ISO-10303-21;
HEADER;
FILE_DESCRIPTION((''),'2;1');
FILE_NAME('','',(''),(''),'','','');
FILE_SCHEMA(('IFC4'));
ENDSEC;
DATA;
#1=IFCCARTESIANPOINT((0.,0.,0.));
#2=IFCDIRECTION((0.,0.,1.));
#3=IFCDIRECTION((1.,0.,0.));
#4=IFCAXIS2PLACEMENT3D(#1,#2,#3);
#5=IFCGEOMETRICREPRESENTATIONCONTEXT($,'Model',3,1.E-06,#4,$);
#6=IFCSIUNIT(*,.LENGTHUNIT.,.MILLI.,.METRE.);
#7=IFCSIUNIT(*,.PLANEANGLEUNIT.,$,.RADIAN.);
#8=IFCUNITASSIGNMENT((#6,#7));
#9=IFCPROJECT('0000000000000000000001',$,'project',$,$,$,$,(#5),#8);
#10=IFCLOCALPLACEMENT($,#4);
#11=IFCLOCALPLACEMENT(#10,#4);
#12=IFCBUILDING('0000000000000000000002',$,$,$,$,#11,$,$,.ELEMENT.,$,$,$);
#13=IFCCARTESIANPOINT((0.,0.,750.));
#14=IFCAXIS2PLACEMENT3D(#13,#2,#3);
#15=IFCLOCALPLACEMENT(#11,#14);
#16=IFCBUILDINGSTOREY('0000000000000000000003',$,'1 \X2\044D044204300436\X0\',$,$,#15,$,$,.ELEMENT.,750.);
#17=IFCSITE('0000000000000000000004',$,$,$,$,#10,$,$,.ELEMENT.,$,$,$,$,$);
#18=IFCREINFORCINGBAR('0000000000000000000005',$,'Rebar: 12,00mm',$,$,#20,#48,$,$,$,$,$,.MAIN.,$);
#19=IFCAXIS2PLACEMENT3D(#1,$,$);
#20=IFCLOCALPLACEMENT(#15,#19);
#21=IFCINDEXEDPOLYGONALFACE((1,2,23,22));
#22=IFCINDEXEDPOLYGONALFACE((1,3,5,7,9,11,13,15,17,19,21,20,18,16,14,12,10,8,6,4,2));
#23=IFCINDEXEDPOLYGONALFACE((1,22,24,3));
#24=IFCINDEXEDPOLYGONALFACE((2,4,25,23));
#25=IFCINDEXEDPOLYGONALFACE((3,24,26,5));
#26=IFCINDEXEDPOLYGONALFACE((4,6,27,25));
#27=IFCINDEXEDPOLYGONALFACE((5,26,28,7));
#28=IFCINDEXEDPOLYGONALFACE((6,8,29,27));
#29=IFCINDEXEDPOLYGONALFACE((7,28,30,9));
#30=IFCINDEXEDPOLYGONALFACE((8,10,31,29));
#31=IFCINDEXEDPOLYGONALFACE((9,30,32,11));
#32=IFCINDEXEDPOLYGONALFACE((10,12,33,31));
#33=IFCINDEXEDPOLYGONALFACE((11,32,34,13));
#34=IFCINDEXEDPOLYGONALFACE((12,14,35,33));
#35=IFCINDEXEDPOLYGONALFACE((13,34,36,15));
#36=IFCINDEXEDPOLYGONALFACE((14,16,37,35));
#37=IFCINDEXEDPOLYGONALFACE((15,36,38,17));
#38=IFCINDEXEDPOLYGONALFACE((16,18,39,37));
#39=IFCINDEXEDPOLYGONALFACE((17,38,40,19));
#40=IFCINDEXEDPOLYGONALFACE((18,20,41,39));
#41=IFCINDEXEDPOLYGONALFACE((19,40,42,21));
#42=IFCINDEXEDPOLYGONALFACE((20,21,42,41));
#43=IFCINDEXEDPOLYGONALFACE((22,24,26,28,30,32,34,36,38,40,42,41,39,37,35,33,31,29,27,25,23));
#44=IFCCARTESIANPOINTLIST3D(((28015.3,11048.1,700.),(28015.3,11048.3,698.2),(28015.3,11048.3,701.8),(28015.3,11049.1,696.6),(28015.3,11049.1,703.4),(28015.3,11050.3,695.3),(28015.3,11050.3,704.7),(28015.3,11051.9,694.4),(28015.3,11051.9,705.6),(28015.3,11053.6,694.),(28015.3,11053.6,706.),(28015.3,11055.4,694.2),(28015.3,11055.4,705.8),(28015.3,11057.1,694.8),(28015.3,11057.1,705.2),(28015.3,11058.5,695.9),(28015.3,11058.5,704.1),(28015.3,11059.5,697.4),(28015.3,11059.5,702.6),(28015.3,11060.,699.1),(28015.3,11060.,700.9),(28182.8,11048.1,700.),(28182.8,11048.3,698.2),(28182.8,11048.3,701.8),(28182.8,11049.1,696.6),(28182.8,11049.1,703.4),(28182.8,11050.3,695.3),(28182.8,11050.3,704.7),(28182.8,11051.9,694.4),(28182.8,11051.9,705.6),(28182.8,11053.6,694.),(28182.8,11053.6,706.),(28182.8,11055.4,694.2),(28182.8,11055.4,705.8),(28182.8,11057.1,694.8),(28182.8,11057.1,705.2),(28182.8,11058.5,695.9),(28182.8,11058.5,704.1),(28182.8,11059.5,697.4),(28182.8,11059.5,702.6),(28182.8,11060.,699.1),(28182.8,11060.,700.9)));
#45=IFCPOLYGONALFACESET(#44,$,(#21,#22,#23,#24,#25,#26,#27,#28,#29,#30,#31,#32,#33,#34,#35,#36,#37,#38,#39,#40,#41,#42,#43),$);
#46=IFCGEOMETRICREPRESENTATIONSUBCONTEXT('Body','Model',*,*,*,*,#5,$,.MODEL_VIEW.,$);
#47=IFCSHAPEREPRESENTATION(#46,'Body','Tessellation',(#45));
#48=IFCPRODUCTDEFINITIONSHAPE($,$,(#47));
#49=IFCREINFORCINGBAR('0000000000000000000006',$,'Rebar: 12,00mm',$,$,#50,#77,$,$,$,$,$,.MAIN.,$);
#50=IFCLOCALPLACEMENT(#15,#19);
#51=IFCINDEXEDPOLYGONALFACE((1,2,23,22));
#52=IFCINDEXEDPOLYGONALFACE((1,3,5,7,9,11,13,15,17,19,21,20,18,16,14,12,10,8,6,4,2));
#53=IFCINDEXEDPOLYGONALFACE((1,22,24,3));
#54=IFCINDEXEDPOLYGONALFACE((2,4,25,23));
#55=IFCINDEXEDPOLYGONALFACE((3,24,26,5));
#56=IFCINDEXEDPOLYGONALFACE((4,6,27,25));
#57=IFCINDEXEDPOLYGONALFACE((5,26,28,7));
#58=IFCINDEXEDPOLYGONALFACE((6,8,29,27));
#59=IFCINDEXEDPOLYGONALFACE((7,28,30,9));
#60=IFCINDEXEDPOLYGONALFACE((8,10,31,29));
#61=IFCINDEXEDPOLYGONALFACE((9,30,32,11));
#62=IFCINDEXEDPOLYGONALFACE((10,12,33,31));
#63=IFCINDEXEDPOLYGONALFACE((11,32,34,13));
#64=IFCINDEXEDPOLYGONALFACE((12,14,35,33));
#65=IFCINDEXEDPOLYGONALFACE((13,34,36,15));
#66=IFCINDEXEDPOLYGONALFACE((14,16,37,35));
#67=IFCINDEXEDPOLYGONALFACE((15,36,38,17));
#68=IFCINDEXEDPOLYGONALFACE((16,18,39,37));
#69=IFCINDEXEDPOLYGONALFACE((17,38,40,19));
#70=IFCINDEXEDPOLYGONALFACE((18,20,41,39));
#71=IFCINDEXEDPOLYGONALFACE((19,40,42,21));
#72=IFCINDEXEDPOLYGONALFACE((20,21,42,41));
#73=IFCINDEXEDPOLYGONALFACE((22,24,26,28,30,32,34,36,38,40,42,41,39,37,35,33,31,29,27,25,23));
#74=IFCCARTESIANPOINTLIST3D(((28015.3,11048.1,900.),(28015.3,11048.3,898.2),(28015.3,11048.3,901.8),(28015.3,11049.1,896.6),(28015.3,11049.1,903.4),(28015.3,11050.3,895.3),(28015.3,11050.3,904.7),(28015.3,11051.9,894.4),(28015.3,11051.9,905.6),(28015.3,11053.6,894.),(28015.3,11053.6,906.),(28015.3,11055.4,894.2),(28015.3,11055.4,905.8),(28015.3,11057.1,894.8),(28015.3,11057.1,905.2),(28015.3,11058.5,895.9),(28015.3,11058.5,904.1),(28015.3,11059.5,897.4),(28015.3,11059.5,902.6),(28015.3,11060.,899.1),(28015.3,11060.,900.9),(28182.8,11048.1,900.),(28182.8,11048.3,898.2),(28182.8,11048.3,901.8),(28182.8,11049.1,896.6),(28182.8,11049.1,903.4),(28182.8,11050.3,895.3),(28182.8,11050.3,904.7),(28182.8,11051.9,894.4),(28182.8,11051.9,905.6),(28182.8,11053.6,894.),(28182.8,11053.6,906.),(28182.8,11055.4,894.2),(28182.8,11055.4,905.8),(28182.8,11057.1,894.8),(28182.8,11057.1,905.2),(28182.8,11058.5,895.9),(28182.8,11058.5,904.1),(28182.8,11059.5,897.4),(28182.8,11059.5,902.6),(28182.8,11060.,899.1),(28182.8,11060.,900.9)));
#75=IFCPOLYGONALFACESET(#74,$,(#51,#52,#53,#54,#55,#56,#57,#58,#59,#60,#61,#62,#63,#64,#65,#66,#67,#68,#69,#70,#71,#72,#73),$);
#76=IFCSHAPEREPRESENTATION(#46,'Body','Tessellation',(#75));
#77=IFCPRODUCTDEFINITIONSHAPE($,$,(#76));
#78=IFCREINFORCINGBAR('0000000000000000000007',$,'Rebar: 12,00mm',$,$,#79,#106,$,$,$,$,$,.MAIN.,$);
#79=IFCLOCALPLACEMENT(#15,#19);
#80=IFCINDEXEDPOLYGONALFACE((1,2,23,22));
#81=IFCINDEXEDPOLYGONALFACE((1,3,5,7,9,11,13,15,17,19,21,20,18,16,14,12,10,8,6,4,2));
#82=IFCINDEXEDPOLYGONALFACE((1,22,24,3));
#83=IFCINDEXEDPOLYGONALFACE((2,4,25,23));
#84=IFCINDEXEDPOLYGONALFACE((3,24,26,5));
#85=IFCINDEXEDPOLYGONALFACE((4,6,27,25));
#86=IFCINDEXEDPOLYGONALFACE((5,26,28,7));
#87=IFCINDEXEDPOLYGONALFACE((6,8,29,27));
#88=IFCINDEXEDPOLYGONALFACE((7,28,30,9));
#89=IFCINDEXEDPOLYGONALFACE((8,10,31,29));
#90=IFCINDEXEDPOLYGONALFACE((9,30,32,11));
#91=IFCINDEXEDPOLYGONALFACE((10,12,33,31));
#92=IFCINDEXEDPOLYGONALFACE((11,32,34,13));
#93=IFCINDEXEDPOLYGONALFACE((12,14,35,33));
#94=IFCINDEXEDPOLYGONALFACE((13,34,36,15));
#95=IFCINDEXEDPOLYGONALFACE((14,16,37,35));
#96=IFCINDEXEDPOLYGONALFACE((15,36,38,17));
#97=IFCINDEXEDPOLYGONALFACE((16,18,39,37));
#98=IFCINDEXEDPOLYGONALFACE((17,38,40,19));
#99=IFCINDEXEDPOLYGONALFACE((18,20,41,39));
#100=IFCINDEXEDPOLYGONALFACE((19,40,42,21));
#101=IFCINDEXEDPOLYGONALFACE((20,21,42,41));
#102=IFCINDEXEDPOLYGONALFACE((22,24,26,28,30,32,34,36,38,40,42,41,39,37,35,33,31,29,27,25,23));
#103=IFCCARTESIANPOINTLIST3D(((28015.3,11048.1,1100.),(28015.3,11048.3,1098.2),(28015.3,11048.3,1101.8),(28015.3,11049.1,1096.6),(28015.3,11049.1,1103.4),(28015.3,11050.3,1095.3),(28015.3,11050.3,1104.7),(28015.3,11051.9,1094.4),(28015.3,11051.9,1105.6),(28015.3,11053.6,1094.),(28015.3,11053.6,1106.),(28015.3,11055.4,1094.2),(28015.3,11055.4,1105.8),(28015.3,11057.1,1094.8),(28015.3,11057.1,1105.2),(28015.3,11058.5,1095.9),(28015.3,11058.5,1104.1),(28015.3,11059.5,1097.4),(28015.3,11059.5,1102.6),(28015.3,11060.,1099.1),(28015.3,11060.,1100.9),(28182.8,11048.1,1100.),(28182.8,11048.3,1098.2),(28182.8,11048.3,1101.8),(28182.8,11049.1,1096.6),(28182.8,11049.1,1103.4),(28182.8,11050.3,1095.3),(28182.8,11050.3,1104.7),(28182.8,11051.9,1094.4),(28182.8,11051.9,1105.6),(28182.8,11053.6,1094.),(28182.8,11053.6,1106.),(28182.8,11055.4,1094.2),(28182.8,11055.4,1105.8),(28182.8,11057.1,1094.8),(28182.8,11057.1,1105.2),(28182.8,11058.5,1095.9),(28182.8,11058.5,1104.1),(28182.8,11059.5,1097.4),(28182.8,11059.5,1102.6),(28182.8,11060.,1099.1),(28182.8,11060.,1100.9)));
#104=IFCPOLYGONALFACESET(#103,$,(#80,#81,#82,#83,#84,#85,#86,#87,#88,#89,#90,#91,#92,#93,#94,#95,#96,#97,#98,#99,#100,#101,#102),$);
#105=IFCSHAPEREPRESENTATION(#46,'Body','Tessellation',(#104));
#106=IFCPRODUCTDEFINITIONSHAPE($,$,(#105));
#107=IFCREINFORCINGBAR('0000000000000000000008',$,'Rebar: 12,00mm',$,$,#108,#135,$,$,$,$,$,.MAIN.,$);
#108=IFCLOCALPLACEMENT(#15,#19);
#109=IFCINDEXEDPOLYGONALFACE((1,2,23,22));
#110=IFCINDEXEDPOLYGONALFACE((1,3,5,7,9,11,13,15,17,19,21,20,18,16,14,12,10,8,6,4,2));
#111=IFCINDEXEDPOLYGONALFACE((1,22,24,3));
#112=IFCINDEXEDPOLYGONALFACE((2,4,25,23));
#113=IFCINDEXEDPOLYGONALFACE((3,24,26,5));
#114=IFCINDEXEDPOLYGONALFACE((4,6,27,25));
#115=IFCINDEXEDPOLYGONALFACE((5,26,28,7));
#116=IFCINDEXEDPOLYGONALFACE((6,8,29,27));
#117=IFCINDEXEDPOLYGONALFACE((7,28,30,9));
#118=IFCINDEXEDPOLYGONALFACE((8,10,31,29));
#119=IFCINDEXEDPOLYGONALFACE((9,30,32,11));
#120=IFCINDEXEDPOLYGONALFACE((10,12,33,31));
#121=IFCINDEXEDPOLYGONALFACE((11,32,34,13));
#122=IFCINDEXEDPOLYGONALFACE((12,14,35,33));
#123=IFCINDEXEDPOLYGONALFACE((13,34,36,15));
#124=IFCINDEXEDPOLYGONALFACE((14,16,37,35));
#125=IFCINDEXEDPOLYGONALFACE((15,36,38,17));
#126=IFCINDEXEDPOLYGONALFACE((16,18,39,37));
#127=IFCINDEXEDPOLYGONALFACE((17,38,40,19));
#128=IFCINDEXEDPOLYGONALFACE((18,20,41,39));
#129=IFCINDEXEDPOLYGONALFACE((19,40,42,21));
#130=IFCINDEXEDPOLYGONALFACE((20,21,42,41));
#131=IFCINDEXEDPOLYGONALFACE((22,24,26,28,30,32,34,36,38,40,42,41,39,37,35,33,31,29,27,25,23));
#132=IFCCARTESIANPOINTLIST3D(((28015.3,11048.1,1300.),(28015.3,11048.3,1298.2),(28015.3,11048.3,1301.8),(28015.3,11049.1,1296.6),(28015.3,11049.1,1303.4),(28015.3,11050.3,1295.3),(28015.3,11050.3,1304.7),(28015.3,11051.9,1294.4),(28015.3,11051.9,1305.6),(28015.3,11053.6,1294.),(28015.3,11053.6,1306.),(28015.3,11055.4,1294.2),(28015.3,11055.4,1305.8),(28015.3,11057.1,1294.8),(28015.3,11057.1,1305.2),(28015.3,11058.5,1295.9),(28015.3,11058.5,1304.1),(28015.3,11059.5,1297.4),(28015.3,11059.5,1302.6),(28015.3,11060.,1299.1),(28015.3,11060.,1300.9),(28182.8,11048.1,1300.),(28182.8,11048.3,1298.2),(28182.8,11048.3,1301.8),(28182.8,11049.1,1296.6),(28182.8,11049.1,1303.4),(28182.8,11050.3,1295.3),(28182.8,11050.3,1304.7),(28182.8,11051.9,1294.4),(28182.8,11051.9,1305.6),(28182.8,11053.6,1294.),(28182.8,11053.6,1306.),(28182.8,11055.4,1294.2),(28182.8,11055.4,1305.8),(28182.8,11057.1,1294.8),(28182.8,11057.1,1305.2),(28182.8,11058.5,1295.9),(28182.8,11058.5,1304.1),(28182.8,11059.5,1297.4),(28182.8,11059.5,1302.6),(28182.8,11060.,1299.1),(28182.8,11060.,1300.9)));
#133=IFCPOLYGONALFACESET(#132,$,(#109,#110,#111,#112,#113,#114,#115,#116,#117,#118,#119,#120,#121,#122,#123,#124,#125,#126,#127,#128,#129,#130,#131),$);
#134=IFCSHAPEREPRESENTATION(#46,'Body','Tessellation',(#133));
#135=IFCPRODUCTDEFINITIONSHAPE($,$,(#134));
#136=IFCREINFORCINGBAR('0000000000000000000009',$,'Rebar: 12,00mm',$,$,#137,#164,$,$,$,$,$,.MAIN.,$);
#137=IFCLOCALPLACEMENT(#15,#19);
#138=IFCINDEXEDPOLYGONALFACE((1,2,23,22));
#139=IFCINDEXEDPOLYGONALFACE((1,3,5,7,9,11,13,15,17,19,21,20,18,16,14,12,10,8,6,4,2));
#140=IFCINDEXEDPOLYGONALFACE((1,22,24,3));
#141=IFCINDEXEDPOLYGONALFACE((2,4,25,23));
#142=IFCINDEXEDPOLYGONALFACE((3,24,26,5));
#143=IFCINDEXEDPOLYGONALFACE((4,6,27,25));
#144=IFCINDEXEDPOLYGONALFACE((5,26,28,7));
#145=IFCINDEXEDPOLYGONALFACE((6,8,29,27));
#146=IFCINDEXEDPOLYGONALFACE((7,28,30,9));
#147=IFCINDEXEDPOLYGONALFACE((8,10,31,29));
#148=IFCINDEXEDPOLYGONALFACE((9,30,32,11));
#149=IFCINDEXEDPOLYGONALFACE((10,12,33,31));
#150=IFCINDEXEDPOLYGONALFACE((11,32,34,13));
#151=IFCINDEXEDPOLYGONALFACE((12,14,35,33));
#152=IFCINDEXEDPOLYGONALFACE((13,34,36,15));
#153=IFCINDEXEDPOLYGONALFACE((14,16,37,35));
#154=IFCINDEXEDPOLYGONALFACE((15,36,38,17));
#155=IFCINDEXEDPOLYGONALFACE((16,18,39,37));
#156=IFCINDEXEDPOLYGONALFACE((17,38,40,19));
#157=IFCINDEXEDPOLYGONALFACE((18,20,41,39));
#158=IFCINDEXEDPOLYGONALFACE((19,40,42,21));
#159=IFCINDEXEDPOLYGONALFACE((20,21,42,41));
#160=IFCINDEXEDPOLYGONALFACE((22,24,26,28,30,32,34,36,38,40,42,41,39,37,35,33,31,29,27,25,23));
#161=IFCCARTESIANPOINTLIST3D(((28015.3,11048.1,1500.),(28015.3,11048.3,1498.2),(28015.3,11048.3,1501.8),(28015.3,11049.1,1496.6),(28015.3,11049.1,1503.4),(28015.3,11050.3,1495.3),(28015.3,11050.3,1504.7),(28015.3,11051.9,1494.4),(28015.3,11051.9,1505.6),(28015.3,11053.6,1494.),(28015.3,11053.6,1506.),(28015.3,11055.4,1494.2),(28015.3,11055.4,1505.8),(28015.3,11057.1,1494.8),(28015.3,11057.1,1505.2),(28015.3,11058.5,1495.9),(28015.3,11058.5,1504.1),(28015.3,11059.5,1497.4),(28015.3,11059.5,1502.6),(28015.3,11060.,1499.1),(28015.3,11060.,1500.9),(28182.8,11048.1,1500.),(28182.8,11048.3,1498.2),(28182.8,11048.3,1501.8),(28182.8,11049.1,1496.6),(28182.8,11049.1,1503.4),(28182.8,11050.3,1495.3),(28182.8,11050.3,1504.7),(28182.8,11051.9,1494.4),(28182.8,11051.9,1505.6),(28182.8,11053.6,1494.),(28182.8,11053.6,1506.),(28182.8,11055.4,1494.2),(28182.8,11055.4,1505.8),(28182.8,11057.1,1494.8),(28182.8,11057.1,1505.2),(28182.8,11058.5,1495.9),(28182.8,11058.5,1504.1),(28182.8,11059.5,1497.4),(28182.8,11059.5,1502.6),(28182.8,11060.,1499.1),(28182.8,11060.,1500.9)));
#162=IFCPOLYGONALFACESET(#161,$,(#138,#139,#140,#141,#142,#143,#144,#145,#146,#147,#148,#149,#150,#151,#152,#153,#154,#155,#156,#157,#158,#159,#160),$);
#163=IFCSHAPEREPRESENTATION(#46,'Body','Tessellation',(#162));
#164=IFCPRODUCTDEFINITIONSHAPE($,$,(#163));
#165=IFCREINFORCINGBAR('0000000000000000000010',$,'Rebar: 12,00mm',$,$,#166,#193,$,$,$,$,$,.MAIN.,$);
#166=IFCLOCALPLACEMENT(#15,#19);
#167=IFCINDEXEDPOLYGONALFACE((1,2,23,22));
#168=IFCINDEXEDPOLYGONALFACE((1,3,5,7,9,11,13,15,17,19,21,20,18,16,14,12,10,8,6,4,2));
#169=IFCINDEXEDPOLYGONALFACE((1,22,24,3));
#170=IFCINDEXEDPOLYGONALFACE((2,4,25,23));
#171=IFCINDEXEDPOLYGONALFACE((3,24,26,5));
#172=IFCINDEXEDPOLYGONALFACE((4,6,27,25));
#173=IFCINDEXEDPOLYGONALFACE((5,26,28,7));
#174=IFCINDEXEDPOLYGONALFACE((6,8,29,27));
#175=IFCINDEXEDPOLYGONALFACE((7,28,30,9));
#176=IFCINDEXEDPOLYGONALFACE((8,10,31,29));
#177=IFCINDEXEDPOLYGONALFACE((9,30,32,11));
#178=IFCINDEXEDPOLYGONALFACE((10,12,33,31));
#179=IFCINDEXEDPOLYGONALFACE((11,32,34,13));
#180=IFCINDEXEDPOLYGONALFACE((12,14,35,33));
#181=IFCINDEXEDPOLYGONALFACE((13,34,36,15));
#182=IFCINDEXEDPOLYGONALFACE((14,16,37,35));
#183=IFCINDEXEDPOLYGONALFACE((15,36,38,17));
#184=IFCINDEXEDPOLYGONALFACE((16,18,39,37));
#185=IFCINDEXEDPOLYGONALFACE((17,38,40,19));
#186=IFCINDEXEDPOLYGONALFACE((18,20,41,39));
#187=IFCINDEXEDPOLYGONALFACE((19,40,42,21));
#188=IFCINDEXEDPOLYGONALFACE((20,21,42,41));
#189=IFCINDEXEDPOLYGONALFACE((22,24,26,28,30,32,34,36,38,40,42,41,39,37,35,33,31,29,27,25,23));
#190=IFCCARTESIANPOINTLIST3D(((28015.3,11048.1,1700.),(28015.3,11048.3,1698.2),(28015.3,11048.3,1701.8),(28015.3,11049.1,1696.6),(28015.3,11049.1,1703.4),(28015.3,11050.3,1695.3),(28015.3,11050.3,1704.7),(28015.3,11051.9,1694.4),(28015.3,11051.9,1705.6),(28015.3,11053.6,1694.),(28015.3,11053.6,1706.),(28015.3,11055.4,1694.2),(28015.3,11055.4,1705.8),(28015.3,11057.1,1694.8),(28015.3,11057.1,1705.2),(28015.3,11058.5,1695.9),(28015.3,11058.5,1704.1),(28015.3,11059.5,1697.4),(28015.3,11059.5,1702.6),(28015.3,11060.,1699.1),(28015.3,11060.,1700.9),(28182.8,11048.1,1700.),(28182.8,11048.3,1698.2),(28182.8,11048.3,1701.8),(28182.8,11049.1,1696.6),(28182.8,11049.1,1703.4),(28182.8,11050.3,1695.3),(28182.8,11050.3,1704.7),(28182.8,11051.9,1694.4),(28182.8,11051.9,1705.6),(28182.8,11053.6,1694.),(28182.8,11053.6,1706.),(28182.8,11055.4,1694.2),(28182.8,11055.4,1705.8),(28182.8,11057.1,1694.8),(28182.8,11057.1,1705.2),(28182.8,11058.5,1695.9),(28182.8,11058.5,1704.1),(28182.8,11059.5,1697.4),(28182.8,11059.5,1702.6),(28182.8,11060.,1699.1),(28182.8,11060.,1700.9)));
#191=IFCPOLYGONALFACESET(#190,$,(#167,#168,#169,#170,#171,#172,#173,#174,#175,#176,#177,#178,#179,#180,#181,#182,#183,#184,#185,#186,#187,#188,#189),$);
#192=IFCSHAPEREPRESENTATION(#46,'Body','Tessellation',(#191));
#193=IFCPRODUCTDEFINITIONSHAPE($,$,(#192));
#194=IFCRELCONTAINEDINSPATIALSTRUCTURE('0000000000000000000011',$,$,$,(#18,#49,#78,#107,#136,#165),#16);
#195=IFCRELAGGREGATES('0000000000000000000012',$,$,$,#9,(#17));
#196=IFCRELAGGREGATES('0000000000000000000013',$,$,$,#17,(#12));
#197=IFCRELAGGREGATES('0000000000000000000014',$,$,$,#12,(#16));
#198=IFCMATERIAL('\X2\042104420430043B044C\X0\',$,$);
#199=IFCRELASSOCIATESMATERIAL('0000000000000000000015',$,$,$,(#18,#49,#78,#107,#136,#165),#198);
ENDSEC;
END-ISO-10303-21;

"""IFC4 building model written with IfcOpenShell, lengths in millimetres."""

from ifc_helpers import new_model, entity, si_unit, frame, origin_with_axes, place, context, subcontext, project, spatial, source, transform, mapped, material, element, save


model = new_model("IFC4")

# Units and contexts
model_context = context("Model", 3, precision=1e-06, world=origin_with_axes())
body_context = subcontext(model_context, "Body", "Model", "MODEL_VIEW")
ifc_project = project(units=[si_unit("LENGTHUNIT", "METRE", prefix="MILLI"), si_unit("PLANEANGLEUNIT", "RADIAN")], contexts=[model_context])

# Site, building, storey
site_placement = place(None, origin_with_axes())
site = spatial("IfcSite", under=ifc_project, at=site_placement, CompositionType="ELEMENT")
building_placement = place(site_placement, origin_with_axes())
building = spatial("IfcBuilding", under=site, at=building_placement, CompositionType="ELEMENT")
storey_placement = place(building_placement, frame((0.0, 0.0, 750.0), z_axis=(0.0, 0.0, 1.0), x_axis=(1.0, 0.0, 0.0)))
storey = spatial("IfcBuildingStorey", under=building, at=storey_placement, Name="1 этаж", CompositionType="ELEMENT", Elevation=750.0)

# Reinforcing bars
ifc_material = material(Name="Сталь")
shared_shape_1 = source(origin_with_axes(), body_context, "Body", "AdvancedSweptSolid", [
    entity("IfcSweptDiskSolid", entity("IfcIndexedPolyCurve", entity("IfcCartesianPointList3D", [[0.0, 0.0, 0.0], [167.5, 0.0, 0.0]]), [entity("IfcLineIndex", [1, 2])]), 6.0),
])
reinforcing_bar_1_placement = place(storey_placement, origin_with_axes())
element("IfcReinforcingBar", 1, at=reinforcing_bar_1_placement, inside=storey, material=ifc_material, Name="Rebar: 12,00mm", PredefinedType="MAIN", context=body_context, shape_type="MappedRepresentation", body=[
    mapped(shared_shape_1, transform((28182.8, 11054.1, 700.0), x_axis=(-1.0, 0.0, 0.0), y_axis=(0.0, -1.0, 0.0), z_axis=(0.0, 0.0, 1.0), scale=1.0)),
])
reinforcing_bar_2_placement = place(storey_placement, origin_with_axes())
element("IfcReinforcingBar", 2, at=reinforcing_bar_2_placement, inside=storey, material=ifc_material, Name="Rebar: 12,00mm", PredefinedType="MAIN", context=body_context, shape_type="MappedRepresentation", body=[
    mapped(shared_shape_1, transform((28182.8, 11054.1, 900.0), x_axis=(-1.0, 0.0, 0.0), y_axis=(0.0, -1.0, 0.0), z_axis=(0.0, 0.0, 1.0), scale=1.0)),
])
reinforcing_bar_3_placement = place(storey_placement, origin_with_axes())
element("IfcReinforcingBar", 3, at=reinforcing_bar_3_placement, inside=storey, material=ifc_material, Name="Rebar: 12,00mm", PredefinedType="MAIN", context=body_context, shape_type="MappedRepresentation", body=[
    mapped(shared_shape_1, transform((28182.8, 11054.1, 1100.0), x_axis=(-1.0, 0.0, 0.0), y_axis=(0.0, -1.0, 0.0), z_axis=(0.0, 0.0, 1.0), scale=1.0)),
])
reinforcing_bar_4_placement = place(storey_placement, origin_with_axes())
element("IfcReinforcingBar", 4, at=reinforcing_bar_4_placement, inside=storey, material=ifc_material, Name="Rebar: 12,00mm", PredefinedType="MAIN", context=body_context, shape_type="MappedRepresentation", body=[
    mapped(shared_shape_1, transform((28182.8, 11054.1, 1300.0), x_axis=(-1.0, 0.0, 0.0), y_axis=(0.0, -1.0, 0.0), z_axis=(0.0, 0.0, 1.0), scale=1.0)),
])
reinforcing_bar_5_placement = place(storey_placement, origin_with_axes())
element("IfcReinforcingBar", 5, at=reinforcing_bar_5_placement, inside=storey, material=ifc_material, Name="Rebar: 12,00mm", PredefinedType="MAIN", context=body_context, shape_type="MappedRepresentation", body=[
    mapped(shared_shape_1, transform((28182.8, 11054.1, 1500.0), x_axis=(-1.0, 0.0, 0.0), y_axis=(0.0, -1.0, 0.0), z_axis=(0.0, 0.0, 1.0), scale=1.0)),
])
reinforcing_bar_6_placement = place(storey_placement, origin_with_axes())
element("IfcReinforcingBar", 6, at=reinforcing_bar_6_placement, inside=storey, material=ifc_material, Name="Rebar: 12,00mm", PredefinedType="MAIN", context=body_context, shape_type="MappedRepresentation", body=[
    mapped(shared_shape_1, transform((28182.8, 11054.1, 1700.0), x_axis=(-1.0, 0.0, 0.0), y_axis=(0.0, -1.0, 0.0), z_axis=(0.0, 0.0, 1.0), scale=1.0)),
])

save(model, "model.ifc")
